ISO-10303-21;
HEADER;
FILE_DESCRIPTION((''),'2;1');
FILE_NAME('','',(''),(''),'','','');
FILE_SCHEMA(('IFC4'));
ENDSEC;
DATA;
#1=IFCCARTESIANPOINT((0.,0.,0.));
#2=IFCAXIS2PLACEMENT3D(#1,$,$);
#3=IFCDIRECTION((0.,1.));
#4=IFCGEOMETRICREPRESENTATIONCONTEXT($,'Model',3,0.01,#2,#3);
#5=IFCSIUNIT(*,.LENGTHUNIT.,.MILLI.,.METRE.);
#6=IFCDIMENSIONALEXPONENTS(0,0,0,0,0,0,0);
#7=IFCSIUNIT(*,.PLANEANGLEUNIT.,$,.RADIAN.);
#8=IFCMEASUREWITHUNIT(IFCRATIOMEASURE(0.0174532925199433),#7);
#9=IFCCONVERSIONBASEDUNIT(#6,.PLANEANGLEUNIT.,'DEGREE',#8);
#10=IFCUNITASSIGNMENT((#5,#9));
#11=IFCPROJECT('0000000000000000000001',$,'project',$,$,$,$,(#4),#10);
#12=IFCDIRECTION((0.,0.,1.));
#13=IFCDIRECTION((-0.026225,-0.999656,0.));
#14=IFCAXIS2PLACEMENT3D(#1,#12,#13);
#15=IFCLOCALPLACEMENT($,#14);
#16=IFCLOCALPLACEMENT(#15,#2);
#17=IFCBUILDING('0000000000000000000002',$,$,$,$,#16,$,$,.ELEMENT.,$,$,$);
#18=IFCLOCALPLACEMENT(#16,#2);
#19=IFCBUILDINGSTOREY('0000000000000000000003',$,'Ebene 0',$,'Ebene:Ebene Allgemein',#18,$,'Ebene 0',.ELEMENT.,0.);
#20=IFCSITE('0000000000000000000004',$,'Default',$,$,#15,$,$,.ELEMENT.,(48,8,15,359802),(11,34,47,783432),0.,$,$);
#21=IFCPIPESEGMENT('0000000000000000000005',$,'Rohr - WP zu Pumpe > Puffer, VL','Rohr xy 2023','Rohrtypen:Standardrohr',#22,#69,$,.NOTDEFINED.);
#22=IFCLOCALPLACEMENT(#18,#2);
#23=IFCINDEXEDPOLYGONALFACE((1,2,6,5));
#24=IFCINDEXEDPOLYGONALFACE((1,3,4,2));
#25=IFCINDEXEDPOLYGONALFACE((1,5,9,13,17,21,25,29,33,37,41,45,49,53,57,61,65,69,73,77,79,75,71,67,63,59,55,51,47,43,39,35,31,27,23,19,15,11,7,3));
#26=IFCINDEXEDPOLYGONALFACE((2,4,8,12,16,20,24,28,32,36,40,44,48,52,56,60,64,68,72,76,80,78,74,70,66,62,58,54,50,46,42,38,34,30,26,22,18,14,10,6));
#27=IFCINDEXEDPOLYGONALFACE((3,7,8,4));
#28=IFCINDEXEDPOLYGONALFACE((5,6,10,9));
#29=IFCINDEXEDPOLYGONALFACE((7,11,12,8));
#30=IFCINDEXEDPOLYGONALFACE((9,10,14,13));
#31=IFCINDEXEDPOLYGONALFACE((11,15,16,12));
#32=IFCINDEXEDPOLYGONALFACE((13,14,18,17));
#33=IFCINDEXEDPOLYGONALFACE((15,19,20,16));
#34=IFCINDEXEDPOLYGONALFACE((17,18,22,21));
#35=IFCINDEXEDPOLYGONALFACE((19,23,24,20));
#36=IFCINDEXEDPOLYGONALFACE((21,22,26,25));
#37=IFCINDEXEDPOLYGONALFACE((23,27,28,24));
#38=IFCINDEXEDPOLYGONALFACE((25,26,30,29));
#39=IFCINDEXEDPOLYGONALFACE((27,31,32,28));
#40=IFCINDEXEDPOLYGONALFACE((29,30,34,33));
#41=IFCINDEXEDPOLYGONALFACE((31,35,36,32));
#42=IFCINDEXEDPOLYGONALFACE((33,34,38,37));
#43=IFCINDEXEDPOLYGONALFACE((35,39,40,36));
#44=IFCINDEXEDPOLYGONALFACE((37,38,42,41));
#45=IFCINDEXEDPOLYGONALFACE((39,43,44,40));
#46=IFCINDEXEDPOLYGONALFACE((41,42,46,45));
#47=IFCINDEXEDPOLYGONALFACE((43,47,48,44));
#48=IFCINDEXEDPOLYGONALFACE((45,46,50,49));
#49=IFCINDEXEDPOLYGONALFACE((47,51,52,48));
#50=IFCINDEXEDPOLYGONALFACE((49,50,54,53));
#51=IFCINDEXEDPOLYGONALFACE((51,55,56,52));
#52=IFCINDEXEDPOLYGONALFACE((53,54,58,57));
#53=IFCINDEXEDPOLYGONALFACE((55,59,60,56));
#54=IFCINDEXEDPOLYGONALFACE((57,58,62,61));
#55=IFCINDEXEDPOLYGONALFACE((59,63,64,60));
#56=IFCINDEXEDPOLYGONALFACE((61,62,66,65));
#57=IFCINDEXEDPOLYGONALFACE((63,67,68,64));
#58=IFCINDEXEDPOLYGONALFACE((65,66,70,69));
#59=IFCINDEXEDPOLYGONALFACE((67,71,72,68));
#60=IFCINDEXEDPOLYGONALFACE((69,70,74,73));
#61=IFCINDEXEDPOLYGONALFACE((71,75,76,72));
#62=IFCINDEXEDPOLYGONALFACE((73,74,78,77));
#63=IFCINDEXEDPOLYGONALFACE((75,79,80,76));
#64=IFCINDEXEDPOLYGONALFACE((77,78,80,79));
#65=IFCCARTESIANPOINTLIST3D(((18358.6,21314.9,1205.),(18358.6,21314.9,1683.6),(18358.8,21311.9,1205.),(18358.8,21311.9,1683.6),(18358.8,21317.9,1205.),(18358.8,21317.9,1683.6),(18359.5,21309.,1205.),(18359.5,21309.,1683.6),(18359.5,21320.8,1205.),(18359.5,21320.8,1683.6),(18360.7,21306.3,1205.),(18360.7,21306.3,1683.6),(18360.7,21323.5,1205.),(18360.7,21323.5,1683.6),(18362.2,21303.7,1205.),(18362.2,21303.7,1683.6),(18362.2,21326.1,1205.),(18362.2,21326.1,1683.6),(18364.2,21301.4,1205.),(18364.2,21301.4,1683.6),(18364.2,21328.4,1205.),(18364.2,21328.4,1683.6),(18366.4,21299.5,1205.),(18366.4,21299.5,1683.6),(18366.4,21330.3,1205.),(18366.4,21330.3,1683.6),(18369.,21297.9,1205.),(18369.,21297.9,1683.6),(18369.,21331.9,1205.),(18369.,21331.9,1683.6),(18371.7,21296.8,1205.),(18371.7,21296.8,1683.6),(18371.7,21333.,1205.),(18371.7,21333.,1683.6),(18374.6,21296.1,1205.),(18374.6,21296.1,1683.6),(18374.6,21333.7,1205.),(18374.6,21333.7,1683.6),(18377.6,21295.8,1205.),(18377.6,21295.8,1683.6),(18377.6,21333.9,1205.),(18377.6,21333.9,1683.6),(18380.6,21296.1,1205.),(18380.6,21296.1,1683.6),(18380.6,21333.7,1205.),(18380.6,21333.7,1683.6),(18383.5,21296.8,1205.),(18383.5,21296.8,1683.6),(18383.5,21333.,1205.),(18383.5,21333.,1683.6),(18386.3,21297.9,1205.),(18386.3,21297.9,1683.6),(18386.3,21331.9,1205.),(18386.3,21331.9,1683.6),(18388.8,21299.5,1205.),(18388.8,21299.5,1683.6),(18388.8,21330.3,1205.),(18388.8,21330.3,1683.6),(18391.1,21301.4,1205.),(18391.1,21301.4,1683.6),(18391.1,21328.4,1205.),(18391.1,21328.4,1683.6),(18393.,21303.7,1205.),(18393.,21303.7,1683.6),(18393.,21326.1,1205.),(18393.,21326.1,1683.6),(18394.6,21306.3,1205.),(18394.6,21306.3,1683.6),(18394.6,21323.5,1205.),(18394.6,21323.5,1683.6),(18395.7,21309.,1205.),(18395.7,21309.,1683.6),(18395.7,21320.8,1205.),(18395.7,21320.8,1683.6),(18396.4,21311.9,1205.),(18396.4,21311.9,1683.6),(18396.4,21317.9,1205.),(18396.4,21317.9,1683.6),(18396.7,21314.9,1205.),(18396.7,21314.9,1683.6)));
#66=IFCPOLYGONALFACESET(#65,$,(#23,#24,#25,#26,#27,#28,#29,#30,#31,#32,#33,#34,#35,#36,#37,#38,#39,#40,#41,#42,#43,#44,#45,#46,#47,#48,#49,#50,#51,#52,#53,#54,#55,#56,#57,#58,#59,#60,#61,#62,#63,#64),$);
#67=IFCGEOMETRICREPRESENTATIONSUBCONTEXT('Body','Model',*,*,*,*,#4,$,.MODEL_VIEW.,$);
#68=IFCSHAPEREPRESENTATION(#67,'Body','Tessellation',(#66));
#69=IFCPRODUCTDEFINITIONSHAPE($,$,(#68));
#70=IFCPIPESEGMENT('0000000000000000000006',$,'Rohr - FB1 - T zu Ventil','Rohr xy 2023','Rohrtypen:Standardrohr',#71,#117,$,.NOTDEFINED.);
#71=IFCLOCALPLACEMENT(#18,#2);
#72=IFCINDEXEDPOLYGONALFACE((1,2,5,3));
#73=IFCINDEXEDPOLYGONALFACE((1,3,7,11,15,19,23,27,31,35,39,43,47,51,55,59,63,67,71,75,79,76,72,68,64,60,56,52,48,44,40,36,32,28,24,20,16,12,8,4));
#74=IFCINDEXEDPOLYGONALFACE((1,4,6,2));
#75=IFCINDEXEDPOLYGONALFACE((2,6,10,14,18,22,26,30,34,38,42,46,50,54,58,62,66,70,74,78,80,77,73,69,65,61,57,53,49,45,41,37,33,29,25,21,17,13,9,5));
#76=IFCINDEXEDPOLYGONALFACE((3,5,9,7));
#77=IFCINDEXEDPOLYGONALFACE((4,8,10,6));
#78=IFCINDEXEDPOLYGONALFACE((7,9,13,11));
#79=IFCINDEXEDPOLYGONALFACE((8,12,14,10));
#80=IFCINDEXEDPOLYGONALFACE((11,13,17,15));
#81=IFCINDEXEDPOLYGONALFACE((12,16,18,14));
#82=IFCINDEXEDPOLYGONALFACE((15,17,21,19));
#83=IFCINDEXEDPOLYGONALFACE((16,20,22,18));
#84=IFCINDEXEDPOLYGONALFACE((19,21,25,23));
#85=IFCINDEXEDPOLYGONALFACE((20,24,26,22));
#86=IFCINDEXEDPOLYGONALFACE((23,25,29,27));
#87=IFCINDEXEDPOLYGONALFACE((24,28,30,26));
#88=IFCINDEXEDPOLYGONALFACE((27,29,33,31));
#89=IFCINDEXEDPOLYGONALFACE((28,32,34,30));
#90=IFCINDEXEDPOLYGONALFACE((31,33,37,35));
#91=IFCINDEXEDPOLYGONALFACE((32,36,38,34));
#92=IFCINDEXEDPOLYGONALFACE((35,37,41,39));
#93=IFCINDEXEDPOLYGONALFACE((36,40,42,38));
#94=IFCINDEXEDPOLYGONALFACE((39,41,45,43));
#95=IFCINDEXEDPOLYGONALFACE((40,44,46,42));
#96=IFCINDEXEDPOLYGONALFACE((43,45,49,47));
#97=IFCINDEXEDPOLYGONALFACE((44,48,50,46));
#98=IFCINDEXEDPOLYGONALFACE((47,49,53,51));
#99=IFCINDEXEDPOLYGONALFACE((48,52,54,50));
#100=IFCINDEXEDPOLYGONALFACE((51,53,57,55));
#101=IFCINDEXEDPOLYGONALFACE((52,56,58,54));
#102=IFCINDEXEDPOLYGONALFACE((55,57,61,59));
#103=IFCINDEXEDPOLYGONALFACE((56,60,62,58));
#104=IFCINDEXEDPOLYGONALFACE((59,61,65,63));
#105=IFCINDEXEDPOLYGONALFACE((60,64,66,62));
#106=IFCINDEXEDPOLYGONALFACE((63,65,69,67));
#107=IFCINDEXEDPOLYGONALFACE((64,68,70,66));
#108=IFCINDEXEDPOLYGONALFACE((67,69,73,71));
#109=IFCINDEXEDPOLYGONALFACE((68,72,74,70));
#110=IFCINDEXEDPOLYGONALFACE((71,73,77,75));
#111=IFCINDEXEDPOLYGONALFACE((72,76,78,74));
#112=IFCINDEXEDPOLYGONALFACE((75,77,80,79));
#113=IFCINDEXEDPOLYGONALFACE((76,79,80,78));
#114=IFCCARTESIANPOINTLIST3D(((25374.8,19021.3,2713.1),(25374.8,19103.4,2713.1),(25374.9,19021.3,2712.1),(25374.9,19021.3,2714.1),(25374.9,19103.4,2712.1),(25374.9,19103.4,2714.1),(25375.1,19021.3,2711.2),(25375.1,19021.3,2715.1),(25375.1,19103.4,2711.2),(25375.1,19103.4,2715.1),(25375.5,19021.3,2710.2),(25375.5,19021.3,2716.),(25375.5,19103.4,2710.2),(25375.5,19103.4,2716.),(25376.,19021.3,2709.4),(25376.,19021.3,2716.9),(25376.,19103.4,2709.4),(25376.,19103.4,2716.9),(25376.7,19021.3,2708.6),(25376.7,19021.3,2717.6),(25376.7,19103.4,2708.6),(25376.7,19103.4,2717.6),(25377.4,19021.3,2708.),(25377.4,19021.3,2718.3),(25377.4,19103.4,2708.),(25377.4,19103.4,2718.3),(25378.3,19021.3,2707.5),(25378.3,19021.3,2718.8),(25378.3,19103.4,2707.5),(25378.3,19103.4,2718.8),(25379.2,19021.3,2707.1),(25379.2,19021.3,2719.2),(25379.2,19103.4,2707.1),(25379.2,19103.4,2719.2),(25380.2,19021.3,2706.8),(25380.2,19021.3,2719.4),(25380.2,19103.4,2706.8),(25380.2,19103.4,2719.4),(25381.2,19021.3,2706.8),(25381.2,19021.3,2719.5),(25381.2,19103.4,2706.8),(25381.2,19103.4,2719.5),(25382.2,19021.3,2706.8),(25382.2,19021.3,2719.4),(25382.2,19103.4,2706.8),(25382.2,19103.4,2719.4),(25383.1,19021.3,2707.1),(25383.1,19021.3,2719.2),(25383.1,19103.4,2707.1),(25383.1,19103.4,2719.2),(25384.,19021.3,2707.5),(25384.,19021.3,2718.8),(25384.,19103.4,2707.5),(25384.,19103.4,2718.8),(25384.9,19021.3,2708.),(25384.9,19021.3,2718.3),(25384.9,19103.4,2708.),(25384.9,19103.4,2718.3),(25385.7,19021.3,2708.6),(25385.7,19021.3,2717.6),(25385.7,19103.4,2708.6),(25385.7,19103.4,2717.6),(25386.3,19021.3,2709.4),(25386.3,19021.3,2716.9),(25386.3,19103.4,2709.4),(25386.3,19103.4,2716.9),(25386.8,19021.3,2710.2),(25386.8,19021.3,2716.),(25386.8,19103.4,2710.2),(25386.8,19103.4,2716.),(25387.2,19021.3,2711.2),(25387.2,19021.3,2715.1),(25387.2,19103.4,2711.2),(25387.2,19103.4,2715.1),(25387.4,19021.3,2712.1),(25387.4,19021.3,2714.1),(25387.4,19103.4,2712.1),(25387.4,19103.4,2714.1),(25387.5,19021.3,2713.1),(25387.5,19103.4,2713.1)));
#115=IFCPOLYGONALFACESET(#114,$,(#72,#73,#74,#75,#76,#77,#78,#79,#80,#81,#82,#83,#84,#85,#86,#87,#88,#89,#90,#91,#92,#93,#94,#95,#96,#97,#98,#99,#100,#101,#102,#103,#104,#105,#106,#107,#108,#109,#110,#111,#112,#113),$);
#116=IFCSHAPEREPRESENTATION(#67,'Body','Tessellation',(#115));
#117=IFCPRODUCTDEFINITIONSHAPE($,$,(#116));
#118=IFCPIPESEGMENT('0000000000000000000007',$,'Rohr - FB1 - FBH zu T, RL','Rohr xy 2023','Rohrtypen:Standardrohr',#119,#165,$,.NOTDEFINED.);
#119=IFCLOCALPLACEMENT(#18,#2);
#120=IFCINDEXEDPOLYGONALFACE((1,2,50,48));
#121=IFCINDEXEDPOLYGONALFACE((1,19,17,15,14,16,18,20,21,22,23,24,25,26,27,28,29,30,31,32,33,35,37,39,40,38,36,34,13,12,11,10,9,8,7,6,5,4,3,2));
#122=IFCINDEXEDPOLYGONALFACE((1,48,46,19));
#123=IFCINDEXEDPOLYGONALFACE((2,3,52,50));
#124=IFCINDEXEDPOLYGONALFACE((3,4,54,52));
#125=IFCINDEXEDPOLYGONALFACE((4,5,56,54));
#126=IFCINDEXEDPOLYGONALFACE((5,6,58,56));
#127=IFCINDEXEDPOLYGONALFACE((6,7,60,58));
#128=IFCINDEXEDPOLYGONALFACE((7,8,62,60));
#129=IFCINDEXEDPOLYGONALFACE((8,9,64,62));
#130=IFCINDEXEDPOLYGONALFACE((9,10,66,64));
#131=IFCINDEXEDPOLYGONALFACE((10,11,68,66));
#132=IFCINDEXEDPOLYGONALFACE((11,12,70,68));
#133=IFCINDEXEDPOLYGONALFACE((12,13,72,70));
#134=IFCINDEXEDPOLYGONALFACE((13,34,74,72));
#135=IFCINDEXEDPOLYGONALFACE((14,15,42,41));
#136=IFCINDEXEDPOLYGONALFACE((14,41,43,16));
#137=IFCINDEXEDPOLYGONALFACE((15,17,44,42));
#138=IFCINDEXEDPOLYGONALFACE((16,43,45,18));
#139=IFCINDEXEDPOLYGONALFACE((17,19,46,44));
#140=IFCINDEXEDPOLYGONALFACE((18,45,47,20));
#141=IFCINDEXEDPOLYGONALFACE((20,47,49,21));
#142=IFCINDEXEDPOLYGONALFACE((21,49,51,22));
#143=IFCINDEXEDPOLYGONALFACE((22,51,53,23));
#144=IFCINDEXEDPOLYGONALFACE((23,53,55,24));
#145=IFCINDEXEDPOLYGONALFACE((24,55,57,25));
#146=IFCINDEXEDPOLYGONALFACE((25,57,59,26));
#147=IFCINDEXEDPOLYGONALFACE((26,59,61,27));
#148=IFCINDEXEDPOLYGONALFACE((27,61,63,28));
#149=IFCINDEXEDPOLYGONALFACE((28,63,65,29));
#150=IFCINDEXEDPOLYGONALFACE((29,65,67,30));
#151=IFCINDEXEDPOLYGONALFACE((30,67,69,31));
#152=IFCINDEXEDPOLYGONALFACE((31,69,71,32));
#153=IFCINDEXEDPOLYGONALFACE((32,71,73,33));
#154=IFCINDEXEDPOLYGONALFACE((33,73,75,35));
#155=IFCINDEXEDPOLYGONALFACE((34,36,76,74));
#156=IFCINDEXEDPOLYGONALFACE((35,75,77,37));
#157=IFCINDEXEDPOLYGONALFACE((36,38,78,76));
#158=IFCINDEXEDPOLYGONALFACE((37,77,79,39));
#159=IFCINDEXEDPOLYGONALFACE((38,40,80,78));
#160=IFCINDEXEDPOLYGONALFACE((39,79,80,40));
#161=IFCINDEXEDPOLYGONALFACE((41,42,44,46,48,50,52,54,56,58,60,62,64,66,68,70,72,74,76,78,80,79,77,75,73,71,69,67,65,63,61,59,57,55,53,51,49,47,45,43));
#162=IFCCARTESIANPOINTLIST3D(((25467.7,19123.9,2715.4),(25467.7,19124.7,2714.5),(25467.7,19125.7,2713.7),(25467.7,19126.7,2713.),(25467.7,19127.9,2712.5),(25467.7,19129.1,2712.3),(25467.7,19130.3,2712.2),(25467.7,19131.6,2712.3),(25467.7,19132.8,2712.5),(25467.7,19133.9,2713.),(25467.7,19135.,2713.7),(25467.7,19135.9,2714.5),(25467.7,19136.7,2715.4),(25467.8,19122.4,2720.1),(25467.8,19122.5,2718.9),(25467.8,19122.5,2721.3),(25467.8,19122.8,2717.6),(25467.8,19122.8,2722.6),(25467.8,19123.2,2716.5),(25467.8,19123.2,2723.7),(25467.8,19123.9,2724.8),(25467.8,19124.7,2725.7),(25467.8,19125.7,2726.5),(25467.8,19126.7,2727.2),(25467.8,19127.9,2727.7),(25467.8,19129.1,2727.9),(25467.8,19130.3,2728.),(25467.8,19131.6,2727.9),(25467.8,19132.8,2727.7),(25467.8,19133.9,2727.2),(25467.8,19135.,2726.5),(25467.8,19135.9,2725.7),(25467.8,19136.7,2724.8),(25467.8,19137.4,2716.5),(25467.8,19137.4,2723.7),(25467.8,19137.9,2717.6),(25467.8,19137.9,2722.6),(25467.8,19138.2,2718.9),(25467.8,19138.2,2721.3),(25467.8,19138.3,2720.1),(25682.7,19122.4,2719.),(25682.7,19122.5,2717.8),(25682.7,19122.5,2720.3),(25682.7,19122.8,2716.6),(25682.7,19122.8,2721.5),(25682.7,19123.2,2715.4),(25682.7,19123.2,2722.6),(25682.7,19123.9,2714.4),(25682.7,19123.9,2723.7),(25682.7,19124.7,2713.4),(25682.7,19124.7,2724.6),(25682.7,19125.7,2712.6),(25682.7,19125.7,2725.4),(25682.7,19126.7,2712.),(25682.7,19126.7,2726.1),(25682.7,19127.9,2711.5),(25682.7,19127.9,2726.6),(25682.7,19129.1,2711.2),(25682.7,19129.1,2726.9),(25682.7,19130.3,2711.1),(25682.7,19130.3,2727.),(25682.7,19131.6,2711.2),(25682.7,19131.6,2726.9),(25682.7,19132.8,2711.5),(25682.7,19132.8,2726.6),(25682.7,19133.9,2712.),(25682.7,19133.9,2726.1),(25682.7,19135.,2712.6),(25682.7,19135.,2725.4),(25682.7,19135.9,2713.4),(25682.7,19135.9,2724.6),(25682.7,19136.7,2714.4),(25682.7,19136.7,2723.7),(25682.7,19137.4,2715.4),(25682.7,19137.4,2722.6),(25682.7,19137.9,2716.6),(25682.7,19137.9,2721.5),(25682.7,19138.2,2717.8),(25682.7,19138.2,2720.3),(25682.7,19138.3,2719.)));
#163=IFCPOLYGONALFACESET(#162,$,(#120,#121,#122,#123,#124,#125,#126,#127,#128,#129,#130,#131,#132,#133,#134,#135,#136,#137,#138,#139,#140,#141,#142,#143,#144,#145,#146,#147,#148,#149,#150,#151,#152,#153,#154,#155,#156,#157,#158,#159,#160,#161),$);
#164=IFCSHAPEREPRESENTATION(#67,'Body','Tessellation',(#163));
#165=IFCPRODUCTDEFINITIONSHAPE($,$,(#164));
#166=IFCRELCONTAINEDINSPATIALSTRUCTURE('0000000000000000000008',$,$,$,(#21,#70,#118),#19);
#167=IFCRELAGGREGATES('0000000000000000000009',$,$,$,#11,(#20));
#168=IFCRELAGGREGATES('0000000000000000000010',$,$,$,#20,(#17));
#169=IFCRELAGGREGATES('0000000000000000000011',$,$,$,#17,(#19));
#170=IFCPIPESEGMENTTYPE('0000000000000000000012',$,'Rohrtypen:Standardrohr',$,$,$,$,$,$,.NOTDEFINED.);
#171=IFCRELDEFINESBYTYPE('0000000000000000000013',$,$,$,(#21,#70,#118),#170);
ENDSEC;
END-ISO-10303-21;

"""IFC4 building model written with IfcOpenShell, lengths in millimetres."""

from ifc_helpers import new_model, entity, si_unit, converted_unit, direction, frame, origin, place, context, subcontext, project, spatial, indexed_curve, outline, extrude, type_object, element, save


model = new_model("IFC4")

# Units and contexts
model_context = context("Model", 3, precision=0.01, world=origin(), true_north=direction((0.0, 1.0)))
body_context = subcontext(model_context, "Body", "Model", "MODEL_VIEW")
ifc_project = project(units=[si_unit("LENGTHUNIT", "METRE", prefix="MILLI"), converted_unit("PLANEANGLEUNIT", "DEGREE", entity("IfcRatioMeasure", 0.0174532925199433), si_unit("PLANEANGLEUNIT", "RADIAN"), dimensions=[0, 0, 0, 0, 0, 0, 0])], contexts=[model_context])

# Site, building, storey
site_placement = place(None, frame((0.0, 0.0, 0.0), z_axis=(0.0, 0.0, 1.0), x_axis=(-0.026225, -0.999656, 0.0)))
site = spatial("IfcSite", under=ifc_project, at=site_placement, Name="Default", CompositionType="ELEMENT", RefLatitude=(48, 8, 15, 359802), RefLongitude=(11, 34, 47, 783432), RefElevation=0.0)
building_placement = place(site_placement, origin())
building = spatial("IfcBuilding", under=site, at=building_placement, CompositionType="ELEMENT")
storey_placement = place(building_placement, origin())
storey = spatial("IfcBuildingStorey", under=building, at=storey_placement, Name="Ebene 0", ObjectType="Ebene:Ebene Allgemein", LongName="Ebene 0", CompositionType="ELEMENT", Elevation=0.0)

# Pipe segments
pipe_segment_type = type_object("IfcPipeSegmentType", Name="Rohrtypen:Standardrohr", PredefinedType="NOTDEFINED")
pipe_segment_1_placement = place(storey_placement, origin())
element("IfcPipeSegment", 1, at=pipe_segment_1_placement, inside=storey, type_object=pipe_segment_type, Name="Rohr - WP zu Pumpe > Puffer, VL", Description="Rohr xy 2023", ObjectType="Rohrtypen:Standardrohr", PredefinedType="NOTDEFINED", context=body_context, shape_type="SweptSolid", body=[
    extrude(outline(indexed_curve([(19.1, 0.0), (18.8, 3.0), (18.1, 5.9), (17.0, 8.6), (15.4, 11.2), (13.5, 13.5), (11.2, 15.4), (8.6, 17.0), (5.9, 18.1), (3.0, 18.8), (0.0, 19.1), (-3.0, 18.8), (-5.9, 18.1), (-8.6, 17.0), (-11.2, 15.4), (-13.5, 13.5), (-15.4, 11.2), (-17.0, 8.6), (-18.1, 5.9), (-18.8, 3.0), (-19.1, 0.0), (-18.8, -3.0), (-18.1, -5.9), (-17.0, -8.6), (-15.4, -11.2), (-13.5, -13.5), (-11.2, -15.4), (-8.6, -17.0), (-5.9, -18.1), (-3.0, -18.8), (0.0, -19.1), (3.0, -18.8), (5.9, -18.1), (8.6, -17.0), (11.2, -15.4), (13.5, -13.5), (15.4, -11.2), (17.0, -8.6), (18.1, -5.9), (18.8, -3.0), (19.1, 0.0)], self_intersect=False)), frame((18377.6, 21314.9, 1205.0), z_axis=(0.0, 0.0, 1.0), x_axis=(-1.0, 0.0, 0.0)), (0.0, 0.0, 1.0), 478.6),
])
pipe_segment_2_placement = place(storey_placement, origin())
element("IfcPipeSegment", 2, at=pipe_segment_2_placement, inside=storey, type_object=pipe_segment_type, Name="Rohr - FB1 - T zu Ventil", Description="Rohr xy 2023", ObjectType="Rohrtypen:Standardrohr", PredefinedType="NOTDEFINED", context=body_context, shape_type="SweptSolid", body=[
    extrude(outline(indexed_curve([(6.3, 0.0), (6.3, 1.0), (6.0, 2.0), (5.7, 2.9), (5.1, 3.7), (4.5, 4.5), (3.7, 5.1), (2.9, 5.7), (2.0, 6.0), (1.0, 6.3), (0.0, 6.4), (-1.0, 6.3), (-2.0, 6.0), (-2.9, 5.7), (-3.7, 5.1), (-4.5, 4.5), (-5.1, 3.7), (-5.7, 2.9), (-6.0, 2.0), (-6.3, 1.0), (-6.3, 0.0), (-6.3, -1.0), (-6.0, -2.0), (-5.7, -2.9), (-5.1, -3.7), (-4.5, -4.5), (-3.7, -5.1), (-2.9, -5.7), (-2.0, -6.0), (-1.0, -6.3), (0.0, -6.4), (1.0, -6.3), (2.0, -6.0), (2.9, -5.7), (3.7, -5.1), (4.5, -4.5), (5.1, -3.7), (5.7, -2.9), (6.0, -2.0), (6.3, -1.0), (6.3, 0.0)], self_intersect=False)), frame((25381.2, 19021.3, 2713.1), z_axis=(0.0, 1.0, 0.0), x_axis=(-1.0, 0.0, 0.0)), (0.0, 0.0, 1.0), 82.2),
])
pipe_segment_3_placement = place(storey_placement, origin())
element("IfcPipeSegment", 3, at=pipe_segment_3_placement, inside=storey, type_object=pipe_segment_type, Name="Rohr - FB1 - FBH zu T, RL", Description="Rohr xy 2023", ObjectType="Rohrtypen:Standardrohr", PredefinedType="NOTDEFINED", context=body_context, shape_type="SweptSolid", body=[
    extrude(outline(indexed_curve([(7.9, 0.0), (7.8, 1.2), (7.6, 2.5), (7.1, 3.6), (6.4, 4.7), (5.6, 5.6), (4.7, 6.4), (3.6, 7.1), (2.5, 7.6), (1.2, 7.8), (0.0, 7.9), (-1.2, 7.8), (-2.5, 7.6), (-3.6, 7.1), (-4.7, 6.4), (-5.6, 5.6), (-6.4, 4.7), (-7.1, 3.6), (-7.6, 2.5), (-7.8, 1.2), (-7.9, 0.0), (-7.8, -1.2), (-7.6, -2.5), (-7.1, -3.6), (-6.4, -4.7), (-5.6, -5.6), (-4.7, -6.4), (-3.6, -7.1), (-2.5, -7.6), (-1.2, -7.8), (0.0, -7.9), (1.2, -7.8), (2.5, -7.6), (3.6, -7.1), (4.7, -6.4), (5.6, -5.6), (6.4, -4.7), (7.1, -3.6), (7.6, -2.5), (7.8, -1.2), (7.9, 0.0)], self_intersect=False)), frame((25682.7, 19130.3, 2719.0), z_axis=(-0.999988, 0.0, 0.005), x_axis=(0.0, 1.0, 0.0)), (0.0, 0.0, 1.0), 214.9),
])

save(model, "model.ifc")
